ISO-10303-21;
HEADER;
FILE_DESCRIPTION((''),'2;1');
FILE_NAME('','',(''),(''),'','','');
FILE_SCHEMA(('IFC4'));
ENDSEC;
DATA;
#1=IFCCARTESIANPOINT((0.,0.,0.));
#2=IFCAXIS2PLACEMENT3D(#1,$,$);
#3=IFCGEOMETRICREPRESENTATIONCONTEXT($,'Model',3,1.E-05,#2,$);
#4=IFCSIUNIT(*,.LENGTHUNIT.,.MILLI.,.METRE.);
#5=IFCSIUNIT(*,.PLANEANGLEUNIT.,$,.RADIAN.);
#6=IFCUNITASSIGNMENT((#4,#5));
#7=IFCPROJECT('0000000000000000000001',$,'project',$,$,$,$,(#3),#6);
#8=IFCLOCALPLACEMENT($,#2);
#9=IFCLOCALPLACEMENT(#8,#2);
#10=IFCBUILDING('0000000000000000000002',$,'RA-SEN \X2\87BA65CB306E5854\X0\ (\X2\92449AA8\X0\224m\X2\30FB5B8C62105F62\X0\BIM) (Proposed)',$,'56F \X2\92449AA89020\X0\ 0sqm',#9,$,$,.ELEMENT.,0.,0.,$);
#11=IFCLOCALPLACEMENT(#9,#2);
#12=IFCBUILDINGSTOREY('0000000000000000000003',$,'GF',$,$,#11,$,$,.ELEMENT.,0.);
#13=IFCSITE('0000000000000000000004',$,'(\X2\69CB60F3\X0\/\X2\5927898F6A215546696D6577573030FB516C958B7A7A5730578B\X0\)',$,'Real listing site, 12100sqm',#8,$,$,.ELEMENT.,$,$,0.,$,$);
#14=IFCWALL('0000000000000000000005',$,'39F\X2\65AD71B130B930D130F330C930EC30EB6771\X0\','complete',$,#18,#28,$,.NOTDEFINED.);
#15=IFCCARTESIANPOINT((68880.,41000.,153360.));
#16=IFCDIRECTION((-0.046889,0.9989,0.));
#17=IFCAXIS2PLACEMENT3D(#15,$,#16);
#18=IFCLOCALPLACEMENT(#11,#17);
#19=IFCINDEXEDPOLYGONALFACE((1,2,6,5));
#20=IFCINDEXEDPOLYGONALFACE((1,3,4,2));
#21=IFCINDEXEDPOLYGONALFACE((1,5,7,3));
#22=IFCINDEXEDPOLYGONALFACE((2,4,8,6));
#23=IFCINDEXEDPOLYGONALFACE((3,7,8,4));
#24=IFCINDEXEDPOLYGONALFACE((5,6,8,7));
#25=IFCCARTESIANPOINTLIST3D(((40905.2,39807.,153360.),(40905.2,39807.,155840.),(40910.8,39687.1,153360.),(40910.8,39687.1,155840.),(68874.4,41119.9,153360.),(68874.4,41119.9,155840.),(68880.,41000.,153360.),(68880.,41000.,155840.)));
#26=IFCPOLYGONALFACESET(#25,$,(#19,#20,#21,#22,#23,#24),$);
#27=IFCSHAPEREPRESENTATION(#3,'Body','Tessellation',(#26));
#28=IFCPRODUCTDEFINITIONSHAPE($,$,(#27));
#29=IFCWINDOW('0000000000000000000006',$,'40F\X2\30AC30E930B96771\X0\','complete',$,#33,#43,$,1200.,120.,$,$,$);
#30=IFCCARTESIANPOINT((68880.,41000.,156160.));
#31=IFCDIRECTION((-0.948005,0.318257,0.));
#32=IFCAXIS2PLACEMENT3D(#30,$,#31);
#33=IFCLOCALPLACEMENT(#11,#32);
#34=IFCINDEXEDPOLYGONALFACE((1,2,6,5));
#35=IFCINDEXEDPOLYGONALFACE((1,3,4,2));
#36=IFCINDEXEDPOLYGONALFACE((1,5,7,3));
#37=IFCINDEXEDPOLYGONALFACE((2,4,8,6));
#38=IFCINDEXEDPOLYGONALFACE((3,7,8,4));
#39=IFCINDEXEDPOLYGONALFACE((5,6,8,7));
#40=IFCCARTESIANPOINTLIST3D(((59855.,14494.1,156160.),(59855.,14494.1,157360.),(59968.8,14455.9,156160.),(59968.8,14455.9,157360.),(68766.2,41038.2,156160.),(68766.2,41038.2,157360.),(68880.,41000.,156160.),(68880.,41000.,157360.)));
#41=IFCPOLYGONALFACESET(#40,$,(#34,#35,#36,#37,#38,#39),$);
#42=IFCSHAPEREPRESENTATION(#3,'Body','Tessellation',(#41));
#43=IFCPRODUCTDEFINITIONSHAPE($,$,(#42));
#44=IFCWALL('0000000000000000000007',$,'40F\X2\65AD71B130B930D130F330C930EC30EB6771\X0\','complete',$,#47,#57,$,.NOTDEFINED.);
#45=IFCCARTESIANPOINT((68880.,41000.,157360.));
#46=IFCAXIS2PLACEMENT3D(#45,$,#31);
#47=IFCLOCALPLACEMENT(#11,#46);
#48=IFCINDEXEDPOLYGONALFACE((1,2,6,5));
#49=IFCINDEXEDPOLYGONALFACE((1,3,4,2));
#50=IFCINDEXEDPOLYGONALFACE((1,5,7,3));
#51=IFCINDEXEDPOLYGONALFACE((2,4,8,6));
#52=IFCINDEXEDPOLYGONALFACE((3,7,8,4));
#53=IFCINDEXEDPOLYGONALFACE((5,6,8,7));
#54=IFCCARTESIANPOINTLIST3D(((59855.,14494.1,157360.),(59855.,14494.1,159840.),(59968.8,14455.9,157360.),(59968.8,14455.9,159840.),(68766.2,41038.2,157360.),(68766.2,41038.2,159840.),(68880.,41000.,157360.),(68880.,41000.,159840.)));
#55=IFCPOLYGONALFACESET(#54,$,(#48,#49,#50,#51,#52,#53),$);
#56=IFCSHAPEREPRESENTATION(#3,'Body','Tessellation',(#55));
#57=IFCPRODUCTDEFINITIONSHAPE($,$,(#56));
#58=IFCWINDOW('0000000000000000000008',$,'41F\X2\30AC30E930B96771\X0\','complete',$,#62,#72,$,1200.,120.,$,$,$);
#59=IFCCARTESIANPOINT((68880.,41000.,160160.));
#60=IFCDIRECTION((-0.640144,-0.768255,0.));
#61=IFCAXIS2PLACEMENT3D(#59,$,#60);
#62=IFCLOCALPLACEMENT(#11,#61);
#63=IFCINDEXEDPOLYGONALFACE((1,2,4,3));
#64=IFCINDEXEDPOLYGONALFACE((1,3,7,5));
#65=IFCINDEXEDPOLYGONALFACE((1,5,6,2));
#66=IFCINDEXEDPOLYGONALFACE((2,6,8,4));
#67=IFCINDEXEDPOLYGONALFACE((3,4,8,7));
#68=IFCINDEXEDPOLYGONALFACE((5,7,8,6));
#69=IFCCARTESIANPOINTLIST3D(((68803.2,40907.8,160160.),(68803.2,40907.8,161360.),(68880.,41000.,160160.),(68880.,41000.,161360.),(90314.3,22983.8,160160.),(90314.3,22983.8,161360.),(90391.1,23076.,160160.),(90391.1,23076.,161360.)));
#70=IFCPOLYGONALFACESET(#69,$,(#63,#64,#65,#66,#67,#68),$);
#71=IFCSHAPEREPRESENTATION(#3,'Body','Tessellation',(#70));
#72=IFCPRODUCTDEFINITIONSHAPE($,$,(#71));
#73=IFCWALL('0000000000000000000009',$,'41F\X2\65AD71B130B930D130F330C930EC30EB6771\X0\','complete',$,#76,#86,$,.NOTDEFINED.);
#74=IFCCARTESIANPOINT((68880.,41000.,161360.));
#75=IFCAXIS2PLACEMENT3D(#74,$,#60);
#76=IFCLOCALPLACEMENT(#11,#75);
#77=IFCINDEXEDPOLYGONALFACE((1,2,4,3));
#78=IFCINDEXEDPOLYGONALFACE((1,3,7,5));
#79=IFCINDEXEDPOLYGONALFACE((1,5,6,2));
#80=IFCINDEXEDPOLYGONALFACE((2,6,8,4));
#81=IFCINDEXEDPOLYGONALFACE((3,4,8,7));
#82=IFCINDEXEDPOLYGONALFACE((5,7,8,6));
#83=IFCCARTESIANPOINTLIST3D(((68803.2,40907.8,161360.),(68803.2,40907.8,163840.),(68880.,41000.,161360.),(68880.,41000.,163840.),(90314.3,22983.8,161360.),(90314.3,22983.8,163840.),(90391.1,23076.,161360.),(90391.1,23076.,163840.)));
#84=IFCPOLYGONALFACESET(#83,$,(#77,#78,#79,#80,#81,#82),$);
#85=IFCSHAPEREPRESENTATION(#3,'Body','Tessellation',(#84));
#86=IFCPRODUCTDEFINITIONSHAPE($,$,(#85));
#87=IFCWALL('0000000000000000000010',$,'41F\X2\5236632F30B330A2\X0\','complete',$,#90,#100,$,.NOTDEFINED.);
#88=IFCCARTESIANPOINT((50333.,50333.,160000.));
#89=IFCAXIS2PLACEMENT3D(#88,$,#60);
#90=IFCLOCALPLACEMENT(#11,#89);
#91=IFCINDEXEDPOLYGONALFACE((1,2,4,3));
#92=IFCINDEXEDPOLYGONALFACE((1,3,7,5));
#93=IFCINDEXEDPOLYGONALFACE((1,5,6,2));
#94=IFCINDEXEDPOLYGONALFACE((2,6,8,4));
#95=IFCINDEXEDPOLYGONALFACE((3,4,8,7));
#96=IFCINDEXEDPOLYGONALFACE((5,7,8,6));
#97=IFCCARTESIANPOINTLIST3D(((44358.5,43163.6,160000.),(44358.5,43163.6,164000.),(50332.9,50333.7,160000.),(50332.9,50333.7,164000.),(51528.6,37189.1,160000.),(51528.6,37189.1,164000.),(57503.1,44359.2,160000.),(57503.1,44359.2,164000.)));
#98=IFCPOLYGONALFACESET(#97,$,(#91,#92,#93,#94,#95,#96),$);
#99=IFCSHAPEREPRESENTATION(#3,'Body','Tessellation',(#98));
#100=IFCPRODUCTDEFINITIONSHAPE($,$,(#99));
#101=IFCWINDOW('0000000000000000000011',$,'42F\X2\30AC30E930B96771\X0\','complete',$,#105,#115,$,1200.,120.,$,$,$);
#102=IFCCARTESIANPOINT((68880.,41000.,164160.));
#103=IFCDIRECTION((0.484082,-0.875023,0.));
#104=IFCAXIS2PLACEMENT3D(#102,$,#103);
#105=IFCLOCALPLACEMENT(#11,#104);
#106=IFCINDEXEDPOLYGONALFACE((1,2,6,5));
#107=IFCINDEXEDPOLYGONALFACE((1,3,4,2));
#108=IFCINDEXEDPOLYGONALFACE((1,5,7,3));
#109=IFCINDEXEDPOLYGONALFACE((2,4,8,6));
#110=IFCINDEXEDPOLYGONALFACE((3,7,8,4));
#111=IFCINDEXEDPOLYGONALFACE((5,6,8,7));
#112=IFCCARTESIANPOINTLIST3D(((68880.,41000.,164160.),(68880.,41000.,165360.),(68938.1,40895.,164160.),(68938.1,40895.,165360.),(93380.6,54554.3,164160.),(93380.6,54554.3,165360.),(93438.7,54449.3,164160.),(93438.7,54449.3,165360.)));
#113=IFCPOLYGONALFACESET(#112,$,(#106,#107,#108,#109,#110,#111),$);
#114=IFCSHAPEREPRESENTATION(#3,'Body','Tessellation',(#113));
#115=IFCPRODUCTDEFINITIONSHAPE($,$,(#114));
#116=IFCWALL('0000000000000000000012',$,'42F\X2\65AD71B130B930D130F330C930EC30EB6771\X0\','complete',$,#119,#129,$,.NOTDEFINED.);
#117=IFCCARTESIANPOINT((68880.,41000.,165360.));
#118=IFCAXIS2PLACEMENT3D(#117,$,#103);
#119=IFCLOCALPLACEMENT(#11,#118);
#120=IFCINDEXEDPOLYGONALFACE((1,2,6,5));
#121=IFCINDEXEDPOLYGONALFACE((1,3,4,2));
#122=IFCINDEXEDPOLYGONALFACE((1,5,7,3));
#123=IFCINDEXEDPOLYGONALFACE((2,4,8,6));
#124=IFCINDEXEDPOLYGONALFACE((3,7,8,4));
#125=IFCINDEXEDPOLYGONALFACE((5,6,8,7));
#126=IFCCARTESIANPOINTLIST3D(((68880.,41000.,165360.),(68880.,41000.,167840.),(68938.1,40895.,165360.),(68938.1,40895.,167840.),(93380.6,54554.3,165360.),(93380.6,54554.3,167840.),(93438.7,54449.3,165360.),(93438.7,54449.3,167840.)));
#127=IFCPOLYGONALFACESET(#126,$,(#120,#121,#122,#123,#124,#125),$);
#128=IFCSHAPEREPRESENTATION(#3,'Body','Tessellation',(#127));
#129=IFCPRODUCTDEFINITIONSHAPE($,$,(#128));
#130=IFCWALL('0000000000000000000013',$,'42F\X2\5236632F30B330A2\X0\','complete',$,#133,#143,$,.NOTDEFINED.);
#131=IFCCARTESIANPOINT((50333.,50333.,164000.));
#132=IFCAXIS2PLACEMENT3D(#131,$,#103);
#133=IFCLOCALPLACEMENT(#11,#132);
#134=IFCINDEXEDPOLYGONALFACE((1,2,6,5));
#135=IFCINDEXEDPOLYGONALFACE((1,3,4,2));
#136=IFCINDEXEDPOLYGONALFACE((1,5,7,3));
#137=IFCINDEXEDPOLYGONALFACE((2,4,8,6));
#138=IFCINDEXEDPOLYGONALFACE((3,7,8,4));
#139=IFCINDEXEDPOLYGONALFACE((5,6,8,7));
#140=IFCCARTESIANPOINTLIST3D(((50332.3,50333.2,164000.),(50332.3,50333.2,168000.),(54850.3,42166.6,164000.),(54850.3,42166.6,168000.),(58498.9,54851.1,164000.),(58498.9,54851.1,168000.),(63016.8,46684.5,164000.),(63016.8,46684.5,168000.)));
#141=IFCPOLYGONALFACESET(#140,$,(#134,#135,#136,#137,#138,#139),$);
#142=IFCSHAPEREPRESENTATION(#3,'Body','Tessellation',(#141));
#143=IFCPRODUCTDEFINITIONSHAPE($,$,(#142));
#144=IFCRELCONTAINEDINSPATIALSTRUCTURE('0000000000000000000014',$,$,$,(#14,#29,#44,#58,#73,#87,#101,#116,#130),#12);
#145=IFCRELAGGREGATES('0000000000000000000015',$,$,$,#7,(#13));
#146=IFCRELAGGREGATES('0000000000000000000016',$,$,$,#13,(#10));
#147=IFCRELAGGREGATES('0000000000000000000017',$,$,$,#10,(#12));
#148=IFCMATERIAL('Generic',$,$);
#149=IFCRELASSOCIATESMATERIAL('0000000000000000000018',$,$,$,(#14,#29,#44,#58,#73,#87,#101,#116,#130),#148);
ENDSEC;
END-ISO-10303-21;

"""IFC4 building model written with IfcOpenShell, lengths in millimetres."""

from ifc_helpers import new_model, si_unit, frame, frame_2d, origin, place, context, project, spatial, rectangle, extrude, material, element, save


model = new_model("IFC4")

# Units and contexts
model_context = context("Model", 3, precision=1e-05, world=origin())
ifc_project = project(units=[si_unit("LENGTHUNIT", "METRE", prefix="MILLI"), si_unit("PLANEANGLEUNIT", "RADIAN")], contexts=[model_context])

# Site, building, storey
site_placement = place(None, origin())
site = spatial("IfcSite", under=ifc_project, at=site_placement, Name="(構想/大規模商業敷地・公開空地型)", ObjectType="Real listing site, 12100sqm", CompositionType="ELEMENT", RefElevation=0.0)
building_placement = place(site_placement, origin())
building = spatial("IfcBuilding", under=site, at=building_placement, Name="RA-SEN 螺旋の塔 (鉄骨224m・完成形BIM) (Proposed)", ObjectType="56F 鉄骨造 0sqm", CompositionType="ELEMENT", ElevationOfRefHeight=0.0, ElevationOfTerrain=0.0)
storey_placement = place(building_placement, origin())
storey = spatial("IfcBuildingStorey", under=building, at=storey_placement, Name="GF", CompositionType="ELEMENT", Elevation=0.0)

# Shared definitions
ifc_material = material(Name="Generic")

# Wall
wall_1_placement = place(storey_placement, frame((68880.0, 41000.0, 153360.0), x_axis=(-0.046889, 0.9989, 0.0)))
element("IfcWall", 1, at=wall_1_placement, inside=storey, material=ifc_material, Name="39F断熱スパンドレル東", Description="complete", PredefinedType="NOTDEFINED", context=model_context, shape_type="SweptSolid", body=[
    extrude(rectangle(XDim=120.0, YDim=28000.0, at=frame_2d((60.0, 14000.0))), frame((68880.0, 41000.0, 153360.0), x_axis=(-0.046889, 0.9989, 0.0)), (0.0, 0.0, 1.0), 2480.0),
])

# Window
window_1_placement = place(storey_placement, frame((68880.0, 41000.0, 156160.0), x_axis=(-0.948005, 0.318257, 0.0)))
element("IfcWindow", 2, at=window_1_placement, inside=storey, material=ifc_material, Name="40Fガラス東", Description="complete", OverallHeight=1200.0, OverallWidth=120.0, context=model_context, shape_type="SweptSolid", body=[
    extrude(rectangle(XDim=120.0, YDim=28000.0, at=frame_2d((60.0, 14000.0))), frame((68880.0, 41000.0, 156160.0), x_axis=(-0.948005, 0.318257, 0.0)), (0.0, 0.0, 1.0), 1200.0),
])

# Wall
wall_2_placement = place(storey_placement, frame((68880.0, 41000.0, 157360.0), x_axis=(-0.948005, 0.318257, 0.0)))
element("IfcWall", 3, at=wall_2_placement, inside=storey, material=ifc_material, Name="40F断熱スパンドレル東", Description="complete", PredefinedType="NOTDEFINED", context=model_context, shape_type="SweptSolid", body=[
    extrude(rectangle(XDim=120.0, YDim=28000.0, at=frame_2d((60.0, 14000.0))), frame((68880.0, 41000.0, 157360.0), x_axis=(-0.948005, 0.318257, 0.0)), (0.0, 0.0, 1.0), 2480.0),
])

# Window
window_2_placement = place(storey_placement, frame((68880.0, 41000.0, 160160.0), x_axis=(-0.640144, -0.768255, 0.0)))
element("IfcWindow", 4, at=window_2_placement, inside=storey, material=ifc_material, Name="41Fガラス東", Description="complete", OverallHeight=1200.0, OverallWidth=120.0, context=model_context, shape_type="SweptSolid", body=[
    extrude(rectangle(XDim=120.0, YDim=28000.0, at=frame_2d((60.0, 14000.0))), frame((68880.0, 41000.0, 160160.0), x_axis=(-0.640144, -0.768255, 0.0)), (0.0, 0.0, 1.0), 1200.0),
])

# Walls
wall_3_placement = place(storey_placement, frame((68880.0, 41000.0, 161360.0), x_axis=(-0.640144, -0.768255, 0.0)))
element("IfcWall", 5, at=wall_3_placement, inside=storey, material=ifc_material, Name="41F断熱スパンドレル東", Description="complete", PredefinedType="NOTDEFINED", context=model_context, shape_type="SweptSolid", body=[
    extrude(rectangle(XDim=120.0, YDim=28000.0, at=frame_2d((60.0, 14000.0))), frame((68880.0, 41000.0, 161360.0), x_axis=(-0.640144, -0.768255, 0.0)), (0.0, 0.0, 1.0), 2480.0),
])
wall_4_placement = place(storey_placement, frame((50333.0, 50333.0, 160000.0), x_axis=(-0.640144, -0.768255, 0.0)))
element("IfcWall", 6, at=wall_4_placement, inside=storey, material=ifc_material, Name="41F制振コア", Description="complete", PredefinedType="NOTDEFINED", context=model_context, shape_type="SweptSolid", body=[
    extrude(rectangle(XDim=9333.0, YDim=9333.0, at=frame_2d((4666.0, 4666.0))), frame((50333.0, 50333.0, 160000.0), x_axis=(-0.640144, -0.768255, 0.0)), (0.0, 0.0, 1.0), 4000.0),
])

# Window
window_3_placement = place(storey_placement, frame((68880.0, 41000.0, 164160.0), x_axis=(0.484082, -0.875023, 0.0)))
element("IfcWindow", 7, at=window_3_placement, inside=storey, material=ifc_material, Name="42Fガラス東", Description="complete", OverallHeight=1200.0, OverallWidth=120.0, context=model_context, shape_type="SweptSolid", body=[
    extrude(rectangle(XDim=120.0, YDim=28000.0, at=frame_2d((60.0, 14000.0))), frame((68880.0, 41000.0, 164160.0), x_axis=(0.484082, -0.875023, 0.0)), (0.0, 0.0, 1.0), 1200.0),
])

# Walls
wall_5_placement = place(storey_placement, frame((68880.0, 41000.0, 165360.0), x_axis=(0.484082, -0.875023, 0.0)))
element("IfcWall", 8, at=wall_5_placement, inside=storey, material=ifc_material, Name="42F断熱スパンドレル東", Description="complete", PredefinedType="NOTDEFINED", context=model_context, shape_type="SweptSolid", body=[
    extrude(rectangle(XDim=120.0, YDim=28000.0, at=frame_2d((60.0, 14000.0))), frame((68880.0, 41000.0, 165360.0), x_axis=(0.484082, -0.875023, 0.0)), (0.0, 0.0, 1.0), 2480.0),
])
wall_6_placement = place(storey_placement, frame((50333.0, 50333.0, 164000.0), x_axis=(0.484082, -0.875023, 0.0)))
element("IfcWall", 9, at=wall_6_placement, inside=storey, material=ifc_material, Name="42F制振コア", Description="complete", PredefinedType="NOTDEFINED", context=model_context, shape_type="SweptSolid", body=[
    extrude(rectangle(XDim=9333.0, YDim=9333.0, at=frame_2d((4666.0, 4666.0))), frame((50333.0, 50333.0, 164000.0), x_axis=(0.484082, -0.875023, 0.0)), (0.0, 0.0, 1.0), 4000.0),
])

save(model, "model.ifc")
